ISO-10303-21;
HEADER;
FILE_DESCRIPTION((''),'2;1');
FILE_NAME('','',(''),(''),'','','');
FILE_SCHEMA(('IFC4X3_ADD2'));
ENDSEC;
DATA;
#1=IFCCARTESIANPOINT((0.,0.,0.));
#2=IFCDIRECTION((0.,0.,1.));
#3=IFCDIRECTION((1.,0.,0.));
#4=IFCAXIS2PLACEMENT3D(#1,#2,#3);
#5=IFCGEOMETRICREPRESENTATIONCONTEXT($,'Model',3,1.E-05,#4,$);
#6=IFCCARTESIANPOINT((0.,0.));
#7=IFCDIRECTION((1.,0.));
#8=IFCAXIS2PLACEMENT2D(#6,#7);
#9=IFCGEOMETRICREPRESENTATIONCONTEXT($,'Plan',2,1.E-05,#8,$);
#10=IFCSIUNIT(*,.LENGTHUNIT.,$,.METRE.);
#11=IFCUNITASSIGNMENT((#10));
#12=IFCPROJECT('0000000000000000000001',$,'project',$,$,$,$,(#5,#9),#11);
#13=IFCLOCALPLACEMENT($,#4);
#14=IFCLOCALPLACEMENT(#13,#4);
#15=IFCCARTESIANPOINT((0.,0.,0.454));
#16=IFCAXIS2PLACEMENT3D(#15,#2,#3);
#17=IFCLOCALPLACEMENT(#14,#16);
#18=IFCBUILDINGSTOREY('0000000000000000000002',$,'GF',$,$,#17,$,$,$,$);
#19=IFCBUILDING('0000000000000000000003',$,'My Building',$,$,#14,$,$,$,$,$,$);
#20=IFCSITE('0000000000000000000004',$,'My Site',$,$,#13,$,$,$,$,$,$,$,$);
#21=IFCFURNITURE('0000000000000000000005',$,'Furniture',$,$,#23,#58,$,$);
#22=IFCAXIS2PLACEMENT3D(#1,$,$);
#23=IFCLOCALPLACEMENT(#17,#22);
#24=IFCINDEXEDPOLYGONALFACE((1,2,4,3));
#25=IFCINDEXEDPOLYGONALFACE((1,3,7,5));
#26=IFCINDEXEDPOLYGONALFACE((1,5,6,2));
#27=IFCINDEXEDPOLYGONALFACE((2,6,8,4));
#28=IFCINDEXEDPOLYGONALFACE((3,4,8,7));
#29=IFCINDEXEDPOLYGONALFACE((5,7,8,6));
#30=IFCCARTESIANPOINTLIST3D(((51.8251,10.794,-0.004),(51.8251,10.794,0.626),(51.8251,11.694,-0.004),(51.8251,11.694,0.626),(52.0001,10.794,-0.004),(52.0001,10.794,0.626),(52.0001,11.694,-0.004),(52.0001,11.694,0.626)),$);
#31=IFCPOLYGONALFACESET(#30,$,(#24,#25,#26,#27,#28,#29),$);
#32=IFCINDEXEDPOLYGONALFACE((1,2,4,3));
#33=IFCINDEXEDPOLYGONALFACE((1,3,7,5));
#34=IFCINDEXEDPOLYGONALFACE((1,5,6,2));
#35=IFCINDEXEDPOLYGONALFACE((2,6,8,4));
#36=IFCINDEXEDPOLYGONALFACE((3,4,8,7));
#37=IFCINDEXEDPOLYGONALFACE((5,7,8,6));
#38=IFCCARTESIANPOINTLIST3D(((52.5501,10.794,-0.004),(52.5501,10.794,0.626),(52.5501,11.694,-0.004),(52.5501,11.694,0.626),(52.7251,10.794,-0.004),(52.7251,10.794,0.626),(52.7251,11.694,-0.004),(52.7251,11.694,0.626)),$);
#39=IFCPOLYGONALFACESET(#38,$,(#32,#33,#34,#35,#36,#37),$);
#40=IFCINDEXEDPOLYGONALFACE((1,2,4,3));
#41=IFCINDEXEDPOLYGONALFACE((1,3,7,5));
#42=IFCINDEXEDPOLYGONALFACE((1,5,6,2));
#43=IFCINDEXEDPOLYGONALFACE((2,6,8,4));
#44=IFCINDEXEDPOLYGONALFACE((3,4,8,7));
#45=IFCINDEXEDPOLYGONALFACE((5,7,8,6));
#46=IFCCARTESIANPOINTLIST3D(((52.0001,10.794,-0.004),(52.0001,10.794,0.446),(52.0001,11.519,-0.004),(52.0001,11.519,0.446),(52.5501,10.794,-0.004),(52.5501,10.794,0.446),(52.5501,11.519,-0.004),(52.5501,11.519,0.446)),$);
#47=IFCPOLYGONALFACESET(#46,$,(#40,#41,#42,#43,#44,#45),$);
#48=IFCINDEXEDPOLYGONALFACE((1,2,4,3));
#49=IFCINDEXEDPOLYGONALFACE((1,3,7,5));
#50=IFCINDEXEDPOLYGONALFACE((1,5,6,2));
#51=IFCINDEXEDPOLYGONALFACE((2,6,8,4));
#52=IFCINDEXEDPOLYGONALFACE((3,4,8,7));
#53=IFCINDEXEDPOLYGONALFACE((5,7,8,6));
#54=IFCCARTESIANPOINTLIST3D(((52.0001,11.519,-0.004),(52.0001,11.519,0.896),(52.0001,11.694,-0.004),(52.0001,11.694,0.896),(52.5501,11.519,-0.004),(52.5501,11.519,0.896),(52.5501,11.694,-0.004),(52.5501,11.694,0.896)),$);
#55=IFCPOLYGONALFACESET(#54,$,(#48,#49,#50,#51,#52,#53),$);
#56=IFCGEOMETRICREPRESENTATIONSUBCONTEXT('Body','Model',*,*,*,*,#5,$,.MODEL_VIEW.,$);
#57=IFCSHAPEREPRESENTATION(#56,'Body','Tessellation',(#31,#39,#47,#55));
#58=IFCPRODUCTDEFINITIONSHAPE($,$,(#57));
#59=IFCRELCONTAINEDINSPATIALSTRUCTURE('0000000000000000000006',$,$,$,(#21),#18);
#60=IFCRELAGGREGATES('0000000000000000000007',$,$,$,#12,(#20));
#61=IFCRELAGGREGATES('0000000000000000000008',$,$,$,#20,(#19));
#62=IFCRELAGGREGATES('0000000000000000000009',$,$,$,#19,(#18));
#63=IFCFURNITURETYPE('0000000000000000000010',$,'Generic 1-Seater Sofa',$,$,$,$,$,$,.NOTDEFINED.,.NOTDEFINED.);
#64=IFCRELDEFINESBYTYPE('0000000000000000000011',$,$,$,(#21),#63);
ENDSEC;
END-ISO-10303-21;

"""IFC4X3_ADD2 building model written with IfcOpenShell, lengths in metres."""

from ifc_helpers import new_model, entity, si_unit, frame, origin_with_axes, origin_2d_with_axis, place, context, subcontext, project, spatial, line, indexed_curve, outline, extrude, shape, source, transform, mapped, type_object, type_shapes, element, save


model = new_model("IFC4X3_ADD2")

# Units and contexts
model_context = context("Model", 3, precision=1e-05, world=origin_with_axes())
plan_context = context("Plan", 2, precision=1e-05, world=origin_2d_with_axis())
body_context_1 = subcontext(model_context, "Body", "Model", "MODEL_VIEW")
body_context_2 = subcontext(plan_context, "Body", "Plan", "PLAN_VIEW")
ifc_project = project(units=[si_unit("LENGTHUNIT", "METRE")], contexts=[model_context, plan_context])

# Site, building, storey
site_placement = place(None, origin_with_axes())
site = spatial("IfcSite", under=ifc_project, at=site_placement, Name="My Site")
building_placement = place(site_placement, origin_with_axes())
building = spatial("IfcBuilding", under=site, at=building_placement, Name="My Building")
storey_placement = place(building_placement, frame((0.0, 0.0, 0.454), z_axis=(0.0, 0.0, 1.0), x_axis=(1.0, 0.0, 0.0)))
storey = spatial("IfcBuildingStorey", under=building, at=storey_placement, Name="GF")

# Furniture
furniture_type_1 = type_object("IfcFurnitureType", Name="Generic 1-Seater Sofa", AssemblyPlace="NOTDEFINED", PredefinedType="NOTDEFINED")
shared_shape_1 = source(origin_with_axes(), body_context_1, "Body", "SweptSolid", [
    extrude(outline(indexed_curve([(0.0, 0.0), (0.175, 0.0), (0.175, 0.9), (0.0, 0.9)], segments=[line(4, 1), line(1, 2), line(2, 3), line(3, 4)], self_intersect=False)), frame((-0.45, -0.9, 0.0), z_axis=(0.0, 0.0, 1.0), x_axis=(1.0, 0.0, 0.0)), (0.0, 0.0, 1.0), 0.63),
    extrude(outline(indexed_curve([(0.0, 0.0), (0.175, 0.0), (0.175, 0.9), (0.0, 0.9)], segments=[line(1, 2, 3, 4, 1)])), frame((0.275, -0.9, 0.0), z_axis=(0.0, 0.0, 1.0), x_axis=(1.0, 0.0, 0.0)), (0.0, 0.0, 1.0), 0.63),
    extrude(outline(indexed_curve([(0.175, 0.0), (0.725, 0.0), (0.725, 0.725), (0.175, 0.725)], segments=[line(1, 2, 3, 4, 1)])), frame((-0.45, -0.9, 0.0), z_axis=(0.0, 0.0, 1.0), x_axis=(1.0, 0.0, 0.0)), (0.0, 0.0, 1.0), 0.45),
    extrude(outline(indexed_curve([(0.175, 0.725), (0.725, 0.725), (0.725, 0.9), (0.175, 0.9)], segments=[line(1, 2, 3, 4, 1)])), frame((-0.45, -0.9, 0.0), z_axis=(0.0, 0.0, 1.0), x_axis=(1.0, 0.0, 0.0)), (0.0, 0.0, 1.0), 0.9),
])
shared_shape_2 = source(origin_with_axes(), body_context_2, "Body", "Annotation2D", [
    entity("IfcGeometricCurveSet", [entity("IfcIndexedPolyCurve", entity("IfcCartesianPointList2D", [[0.275, -0.175], [0.275, -0.9], [0.45, -0.9], [0.45, 0.0], [0.275, 0.0], [0.275, -0.9], [-0.275, -0.9], [-0.275, 0.0], [-0.275, -0.175], [0.275, -0.175], [0.275, 0.0], [-0.275, 0.0], [-0.45, 0.0], [-0.45, -0.9], [-0.275, -0.9], [-0.275, -0.175]]))]),
])
type_shapes(furniture_type_1, [shared_shape_1, shared_shape_2])
for number, where, z_axis, x_axis, name in (
    (1, (52.2751, 11.694, -0.004), (0.0, 0.0, 1.0), (1.0, 0.0, 0.0), "Furniture"),
):
    element("IfcFurniture", number, at=place(storey_placement, frame(where, z_axis=z_axis, x_axis=x_axis)), inside=storey, type_object=furniture_type_1, Name=name, shapes=[
        shape(body_context_1, "Body", "MappedRepresentation", [mapped(shared_shape_1, transform((0.0, 0.0, 0.0), x_axis=(1.0, 0.0, 0.0), y_axis=(0.0, 1.0, 0.0), z_axis=(0.0, 0.0, 1.0), scale=1.0))]),
        shape(body_context_2, "Body", "MappedRepresentation", [mapped(shared_shape_2, transform((0.0, 0.0, 0.0), x_axis=(1.0, 0.0, 0.0), y_axis=(0.0, 1.0, 0.0), z_axis=(0.0, 0.0, 1.0), scale=1.0))]),
    ])

save(model, "model.ifc")
